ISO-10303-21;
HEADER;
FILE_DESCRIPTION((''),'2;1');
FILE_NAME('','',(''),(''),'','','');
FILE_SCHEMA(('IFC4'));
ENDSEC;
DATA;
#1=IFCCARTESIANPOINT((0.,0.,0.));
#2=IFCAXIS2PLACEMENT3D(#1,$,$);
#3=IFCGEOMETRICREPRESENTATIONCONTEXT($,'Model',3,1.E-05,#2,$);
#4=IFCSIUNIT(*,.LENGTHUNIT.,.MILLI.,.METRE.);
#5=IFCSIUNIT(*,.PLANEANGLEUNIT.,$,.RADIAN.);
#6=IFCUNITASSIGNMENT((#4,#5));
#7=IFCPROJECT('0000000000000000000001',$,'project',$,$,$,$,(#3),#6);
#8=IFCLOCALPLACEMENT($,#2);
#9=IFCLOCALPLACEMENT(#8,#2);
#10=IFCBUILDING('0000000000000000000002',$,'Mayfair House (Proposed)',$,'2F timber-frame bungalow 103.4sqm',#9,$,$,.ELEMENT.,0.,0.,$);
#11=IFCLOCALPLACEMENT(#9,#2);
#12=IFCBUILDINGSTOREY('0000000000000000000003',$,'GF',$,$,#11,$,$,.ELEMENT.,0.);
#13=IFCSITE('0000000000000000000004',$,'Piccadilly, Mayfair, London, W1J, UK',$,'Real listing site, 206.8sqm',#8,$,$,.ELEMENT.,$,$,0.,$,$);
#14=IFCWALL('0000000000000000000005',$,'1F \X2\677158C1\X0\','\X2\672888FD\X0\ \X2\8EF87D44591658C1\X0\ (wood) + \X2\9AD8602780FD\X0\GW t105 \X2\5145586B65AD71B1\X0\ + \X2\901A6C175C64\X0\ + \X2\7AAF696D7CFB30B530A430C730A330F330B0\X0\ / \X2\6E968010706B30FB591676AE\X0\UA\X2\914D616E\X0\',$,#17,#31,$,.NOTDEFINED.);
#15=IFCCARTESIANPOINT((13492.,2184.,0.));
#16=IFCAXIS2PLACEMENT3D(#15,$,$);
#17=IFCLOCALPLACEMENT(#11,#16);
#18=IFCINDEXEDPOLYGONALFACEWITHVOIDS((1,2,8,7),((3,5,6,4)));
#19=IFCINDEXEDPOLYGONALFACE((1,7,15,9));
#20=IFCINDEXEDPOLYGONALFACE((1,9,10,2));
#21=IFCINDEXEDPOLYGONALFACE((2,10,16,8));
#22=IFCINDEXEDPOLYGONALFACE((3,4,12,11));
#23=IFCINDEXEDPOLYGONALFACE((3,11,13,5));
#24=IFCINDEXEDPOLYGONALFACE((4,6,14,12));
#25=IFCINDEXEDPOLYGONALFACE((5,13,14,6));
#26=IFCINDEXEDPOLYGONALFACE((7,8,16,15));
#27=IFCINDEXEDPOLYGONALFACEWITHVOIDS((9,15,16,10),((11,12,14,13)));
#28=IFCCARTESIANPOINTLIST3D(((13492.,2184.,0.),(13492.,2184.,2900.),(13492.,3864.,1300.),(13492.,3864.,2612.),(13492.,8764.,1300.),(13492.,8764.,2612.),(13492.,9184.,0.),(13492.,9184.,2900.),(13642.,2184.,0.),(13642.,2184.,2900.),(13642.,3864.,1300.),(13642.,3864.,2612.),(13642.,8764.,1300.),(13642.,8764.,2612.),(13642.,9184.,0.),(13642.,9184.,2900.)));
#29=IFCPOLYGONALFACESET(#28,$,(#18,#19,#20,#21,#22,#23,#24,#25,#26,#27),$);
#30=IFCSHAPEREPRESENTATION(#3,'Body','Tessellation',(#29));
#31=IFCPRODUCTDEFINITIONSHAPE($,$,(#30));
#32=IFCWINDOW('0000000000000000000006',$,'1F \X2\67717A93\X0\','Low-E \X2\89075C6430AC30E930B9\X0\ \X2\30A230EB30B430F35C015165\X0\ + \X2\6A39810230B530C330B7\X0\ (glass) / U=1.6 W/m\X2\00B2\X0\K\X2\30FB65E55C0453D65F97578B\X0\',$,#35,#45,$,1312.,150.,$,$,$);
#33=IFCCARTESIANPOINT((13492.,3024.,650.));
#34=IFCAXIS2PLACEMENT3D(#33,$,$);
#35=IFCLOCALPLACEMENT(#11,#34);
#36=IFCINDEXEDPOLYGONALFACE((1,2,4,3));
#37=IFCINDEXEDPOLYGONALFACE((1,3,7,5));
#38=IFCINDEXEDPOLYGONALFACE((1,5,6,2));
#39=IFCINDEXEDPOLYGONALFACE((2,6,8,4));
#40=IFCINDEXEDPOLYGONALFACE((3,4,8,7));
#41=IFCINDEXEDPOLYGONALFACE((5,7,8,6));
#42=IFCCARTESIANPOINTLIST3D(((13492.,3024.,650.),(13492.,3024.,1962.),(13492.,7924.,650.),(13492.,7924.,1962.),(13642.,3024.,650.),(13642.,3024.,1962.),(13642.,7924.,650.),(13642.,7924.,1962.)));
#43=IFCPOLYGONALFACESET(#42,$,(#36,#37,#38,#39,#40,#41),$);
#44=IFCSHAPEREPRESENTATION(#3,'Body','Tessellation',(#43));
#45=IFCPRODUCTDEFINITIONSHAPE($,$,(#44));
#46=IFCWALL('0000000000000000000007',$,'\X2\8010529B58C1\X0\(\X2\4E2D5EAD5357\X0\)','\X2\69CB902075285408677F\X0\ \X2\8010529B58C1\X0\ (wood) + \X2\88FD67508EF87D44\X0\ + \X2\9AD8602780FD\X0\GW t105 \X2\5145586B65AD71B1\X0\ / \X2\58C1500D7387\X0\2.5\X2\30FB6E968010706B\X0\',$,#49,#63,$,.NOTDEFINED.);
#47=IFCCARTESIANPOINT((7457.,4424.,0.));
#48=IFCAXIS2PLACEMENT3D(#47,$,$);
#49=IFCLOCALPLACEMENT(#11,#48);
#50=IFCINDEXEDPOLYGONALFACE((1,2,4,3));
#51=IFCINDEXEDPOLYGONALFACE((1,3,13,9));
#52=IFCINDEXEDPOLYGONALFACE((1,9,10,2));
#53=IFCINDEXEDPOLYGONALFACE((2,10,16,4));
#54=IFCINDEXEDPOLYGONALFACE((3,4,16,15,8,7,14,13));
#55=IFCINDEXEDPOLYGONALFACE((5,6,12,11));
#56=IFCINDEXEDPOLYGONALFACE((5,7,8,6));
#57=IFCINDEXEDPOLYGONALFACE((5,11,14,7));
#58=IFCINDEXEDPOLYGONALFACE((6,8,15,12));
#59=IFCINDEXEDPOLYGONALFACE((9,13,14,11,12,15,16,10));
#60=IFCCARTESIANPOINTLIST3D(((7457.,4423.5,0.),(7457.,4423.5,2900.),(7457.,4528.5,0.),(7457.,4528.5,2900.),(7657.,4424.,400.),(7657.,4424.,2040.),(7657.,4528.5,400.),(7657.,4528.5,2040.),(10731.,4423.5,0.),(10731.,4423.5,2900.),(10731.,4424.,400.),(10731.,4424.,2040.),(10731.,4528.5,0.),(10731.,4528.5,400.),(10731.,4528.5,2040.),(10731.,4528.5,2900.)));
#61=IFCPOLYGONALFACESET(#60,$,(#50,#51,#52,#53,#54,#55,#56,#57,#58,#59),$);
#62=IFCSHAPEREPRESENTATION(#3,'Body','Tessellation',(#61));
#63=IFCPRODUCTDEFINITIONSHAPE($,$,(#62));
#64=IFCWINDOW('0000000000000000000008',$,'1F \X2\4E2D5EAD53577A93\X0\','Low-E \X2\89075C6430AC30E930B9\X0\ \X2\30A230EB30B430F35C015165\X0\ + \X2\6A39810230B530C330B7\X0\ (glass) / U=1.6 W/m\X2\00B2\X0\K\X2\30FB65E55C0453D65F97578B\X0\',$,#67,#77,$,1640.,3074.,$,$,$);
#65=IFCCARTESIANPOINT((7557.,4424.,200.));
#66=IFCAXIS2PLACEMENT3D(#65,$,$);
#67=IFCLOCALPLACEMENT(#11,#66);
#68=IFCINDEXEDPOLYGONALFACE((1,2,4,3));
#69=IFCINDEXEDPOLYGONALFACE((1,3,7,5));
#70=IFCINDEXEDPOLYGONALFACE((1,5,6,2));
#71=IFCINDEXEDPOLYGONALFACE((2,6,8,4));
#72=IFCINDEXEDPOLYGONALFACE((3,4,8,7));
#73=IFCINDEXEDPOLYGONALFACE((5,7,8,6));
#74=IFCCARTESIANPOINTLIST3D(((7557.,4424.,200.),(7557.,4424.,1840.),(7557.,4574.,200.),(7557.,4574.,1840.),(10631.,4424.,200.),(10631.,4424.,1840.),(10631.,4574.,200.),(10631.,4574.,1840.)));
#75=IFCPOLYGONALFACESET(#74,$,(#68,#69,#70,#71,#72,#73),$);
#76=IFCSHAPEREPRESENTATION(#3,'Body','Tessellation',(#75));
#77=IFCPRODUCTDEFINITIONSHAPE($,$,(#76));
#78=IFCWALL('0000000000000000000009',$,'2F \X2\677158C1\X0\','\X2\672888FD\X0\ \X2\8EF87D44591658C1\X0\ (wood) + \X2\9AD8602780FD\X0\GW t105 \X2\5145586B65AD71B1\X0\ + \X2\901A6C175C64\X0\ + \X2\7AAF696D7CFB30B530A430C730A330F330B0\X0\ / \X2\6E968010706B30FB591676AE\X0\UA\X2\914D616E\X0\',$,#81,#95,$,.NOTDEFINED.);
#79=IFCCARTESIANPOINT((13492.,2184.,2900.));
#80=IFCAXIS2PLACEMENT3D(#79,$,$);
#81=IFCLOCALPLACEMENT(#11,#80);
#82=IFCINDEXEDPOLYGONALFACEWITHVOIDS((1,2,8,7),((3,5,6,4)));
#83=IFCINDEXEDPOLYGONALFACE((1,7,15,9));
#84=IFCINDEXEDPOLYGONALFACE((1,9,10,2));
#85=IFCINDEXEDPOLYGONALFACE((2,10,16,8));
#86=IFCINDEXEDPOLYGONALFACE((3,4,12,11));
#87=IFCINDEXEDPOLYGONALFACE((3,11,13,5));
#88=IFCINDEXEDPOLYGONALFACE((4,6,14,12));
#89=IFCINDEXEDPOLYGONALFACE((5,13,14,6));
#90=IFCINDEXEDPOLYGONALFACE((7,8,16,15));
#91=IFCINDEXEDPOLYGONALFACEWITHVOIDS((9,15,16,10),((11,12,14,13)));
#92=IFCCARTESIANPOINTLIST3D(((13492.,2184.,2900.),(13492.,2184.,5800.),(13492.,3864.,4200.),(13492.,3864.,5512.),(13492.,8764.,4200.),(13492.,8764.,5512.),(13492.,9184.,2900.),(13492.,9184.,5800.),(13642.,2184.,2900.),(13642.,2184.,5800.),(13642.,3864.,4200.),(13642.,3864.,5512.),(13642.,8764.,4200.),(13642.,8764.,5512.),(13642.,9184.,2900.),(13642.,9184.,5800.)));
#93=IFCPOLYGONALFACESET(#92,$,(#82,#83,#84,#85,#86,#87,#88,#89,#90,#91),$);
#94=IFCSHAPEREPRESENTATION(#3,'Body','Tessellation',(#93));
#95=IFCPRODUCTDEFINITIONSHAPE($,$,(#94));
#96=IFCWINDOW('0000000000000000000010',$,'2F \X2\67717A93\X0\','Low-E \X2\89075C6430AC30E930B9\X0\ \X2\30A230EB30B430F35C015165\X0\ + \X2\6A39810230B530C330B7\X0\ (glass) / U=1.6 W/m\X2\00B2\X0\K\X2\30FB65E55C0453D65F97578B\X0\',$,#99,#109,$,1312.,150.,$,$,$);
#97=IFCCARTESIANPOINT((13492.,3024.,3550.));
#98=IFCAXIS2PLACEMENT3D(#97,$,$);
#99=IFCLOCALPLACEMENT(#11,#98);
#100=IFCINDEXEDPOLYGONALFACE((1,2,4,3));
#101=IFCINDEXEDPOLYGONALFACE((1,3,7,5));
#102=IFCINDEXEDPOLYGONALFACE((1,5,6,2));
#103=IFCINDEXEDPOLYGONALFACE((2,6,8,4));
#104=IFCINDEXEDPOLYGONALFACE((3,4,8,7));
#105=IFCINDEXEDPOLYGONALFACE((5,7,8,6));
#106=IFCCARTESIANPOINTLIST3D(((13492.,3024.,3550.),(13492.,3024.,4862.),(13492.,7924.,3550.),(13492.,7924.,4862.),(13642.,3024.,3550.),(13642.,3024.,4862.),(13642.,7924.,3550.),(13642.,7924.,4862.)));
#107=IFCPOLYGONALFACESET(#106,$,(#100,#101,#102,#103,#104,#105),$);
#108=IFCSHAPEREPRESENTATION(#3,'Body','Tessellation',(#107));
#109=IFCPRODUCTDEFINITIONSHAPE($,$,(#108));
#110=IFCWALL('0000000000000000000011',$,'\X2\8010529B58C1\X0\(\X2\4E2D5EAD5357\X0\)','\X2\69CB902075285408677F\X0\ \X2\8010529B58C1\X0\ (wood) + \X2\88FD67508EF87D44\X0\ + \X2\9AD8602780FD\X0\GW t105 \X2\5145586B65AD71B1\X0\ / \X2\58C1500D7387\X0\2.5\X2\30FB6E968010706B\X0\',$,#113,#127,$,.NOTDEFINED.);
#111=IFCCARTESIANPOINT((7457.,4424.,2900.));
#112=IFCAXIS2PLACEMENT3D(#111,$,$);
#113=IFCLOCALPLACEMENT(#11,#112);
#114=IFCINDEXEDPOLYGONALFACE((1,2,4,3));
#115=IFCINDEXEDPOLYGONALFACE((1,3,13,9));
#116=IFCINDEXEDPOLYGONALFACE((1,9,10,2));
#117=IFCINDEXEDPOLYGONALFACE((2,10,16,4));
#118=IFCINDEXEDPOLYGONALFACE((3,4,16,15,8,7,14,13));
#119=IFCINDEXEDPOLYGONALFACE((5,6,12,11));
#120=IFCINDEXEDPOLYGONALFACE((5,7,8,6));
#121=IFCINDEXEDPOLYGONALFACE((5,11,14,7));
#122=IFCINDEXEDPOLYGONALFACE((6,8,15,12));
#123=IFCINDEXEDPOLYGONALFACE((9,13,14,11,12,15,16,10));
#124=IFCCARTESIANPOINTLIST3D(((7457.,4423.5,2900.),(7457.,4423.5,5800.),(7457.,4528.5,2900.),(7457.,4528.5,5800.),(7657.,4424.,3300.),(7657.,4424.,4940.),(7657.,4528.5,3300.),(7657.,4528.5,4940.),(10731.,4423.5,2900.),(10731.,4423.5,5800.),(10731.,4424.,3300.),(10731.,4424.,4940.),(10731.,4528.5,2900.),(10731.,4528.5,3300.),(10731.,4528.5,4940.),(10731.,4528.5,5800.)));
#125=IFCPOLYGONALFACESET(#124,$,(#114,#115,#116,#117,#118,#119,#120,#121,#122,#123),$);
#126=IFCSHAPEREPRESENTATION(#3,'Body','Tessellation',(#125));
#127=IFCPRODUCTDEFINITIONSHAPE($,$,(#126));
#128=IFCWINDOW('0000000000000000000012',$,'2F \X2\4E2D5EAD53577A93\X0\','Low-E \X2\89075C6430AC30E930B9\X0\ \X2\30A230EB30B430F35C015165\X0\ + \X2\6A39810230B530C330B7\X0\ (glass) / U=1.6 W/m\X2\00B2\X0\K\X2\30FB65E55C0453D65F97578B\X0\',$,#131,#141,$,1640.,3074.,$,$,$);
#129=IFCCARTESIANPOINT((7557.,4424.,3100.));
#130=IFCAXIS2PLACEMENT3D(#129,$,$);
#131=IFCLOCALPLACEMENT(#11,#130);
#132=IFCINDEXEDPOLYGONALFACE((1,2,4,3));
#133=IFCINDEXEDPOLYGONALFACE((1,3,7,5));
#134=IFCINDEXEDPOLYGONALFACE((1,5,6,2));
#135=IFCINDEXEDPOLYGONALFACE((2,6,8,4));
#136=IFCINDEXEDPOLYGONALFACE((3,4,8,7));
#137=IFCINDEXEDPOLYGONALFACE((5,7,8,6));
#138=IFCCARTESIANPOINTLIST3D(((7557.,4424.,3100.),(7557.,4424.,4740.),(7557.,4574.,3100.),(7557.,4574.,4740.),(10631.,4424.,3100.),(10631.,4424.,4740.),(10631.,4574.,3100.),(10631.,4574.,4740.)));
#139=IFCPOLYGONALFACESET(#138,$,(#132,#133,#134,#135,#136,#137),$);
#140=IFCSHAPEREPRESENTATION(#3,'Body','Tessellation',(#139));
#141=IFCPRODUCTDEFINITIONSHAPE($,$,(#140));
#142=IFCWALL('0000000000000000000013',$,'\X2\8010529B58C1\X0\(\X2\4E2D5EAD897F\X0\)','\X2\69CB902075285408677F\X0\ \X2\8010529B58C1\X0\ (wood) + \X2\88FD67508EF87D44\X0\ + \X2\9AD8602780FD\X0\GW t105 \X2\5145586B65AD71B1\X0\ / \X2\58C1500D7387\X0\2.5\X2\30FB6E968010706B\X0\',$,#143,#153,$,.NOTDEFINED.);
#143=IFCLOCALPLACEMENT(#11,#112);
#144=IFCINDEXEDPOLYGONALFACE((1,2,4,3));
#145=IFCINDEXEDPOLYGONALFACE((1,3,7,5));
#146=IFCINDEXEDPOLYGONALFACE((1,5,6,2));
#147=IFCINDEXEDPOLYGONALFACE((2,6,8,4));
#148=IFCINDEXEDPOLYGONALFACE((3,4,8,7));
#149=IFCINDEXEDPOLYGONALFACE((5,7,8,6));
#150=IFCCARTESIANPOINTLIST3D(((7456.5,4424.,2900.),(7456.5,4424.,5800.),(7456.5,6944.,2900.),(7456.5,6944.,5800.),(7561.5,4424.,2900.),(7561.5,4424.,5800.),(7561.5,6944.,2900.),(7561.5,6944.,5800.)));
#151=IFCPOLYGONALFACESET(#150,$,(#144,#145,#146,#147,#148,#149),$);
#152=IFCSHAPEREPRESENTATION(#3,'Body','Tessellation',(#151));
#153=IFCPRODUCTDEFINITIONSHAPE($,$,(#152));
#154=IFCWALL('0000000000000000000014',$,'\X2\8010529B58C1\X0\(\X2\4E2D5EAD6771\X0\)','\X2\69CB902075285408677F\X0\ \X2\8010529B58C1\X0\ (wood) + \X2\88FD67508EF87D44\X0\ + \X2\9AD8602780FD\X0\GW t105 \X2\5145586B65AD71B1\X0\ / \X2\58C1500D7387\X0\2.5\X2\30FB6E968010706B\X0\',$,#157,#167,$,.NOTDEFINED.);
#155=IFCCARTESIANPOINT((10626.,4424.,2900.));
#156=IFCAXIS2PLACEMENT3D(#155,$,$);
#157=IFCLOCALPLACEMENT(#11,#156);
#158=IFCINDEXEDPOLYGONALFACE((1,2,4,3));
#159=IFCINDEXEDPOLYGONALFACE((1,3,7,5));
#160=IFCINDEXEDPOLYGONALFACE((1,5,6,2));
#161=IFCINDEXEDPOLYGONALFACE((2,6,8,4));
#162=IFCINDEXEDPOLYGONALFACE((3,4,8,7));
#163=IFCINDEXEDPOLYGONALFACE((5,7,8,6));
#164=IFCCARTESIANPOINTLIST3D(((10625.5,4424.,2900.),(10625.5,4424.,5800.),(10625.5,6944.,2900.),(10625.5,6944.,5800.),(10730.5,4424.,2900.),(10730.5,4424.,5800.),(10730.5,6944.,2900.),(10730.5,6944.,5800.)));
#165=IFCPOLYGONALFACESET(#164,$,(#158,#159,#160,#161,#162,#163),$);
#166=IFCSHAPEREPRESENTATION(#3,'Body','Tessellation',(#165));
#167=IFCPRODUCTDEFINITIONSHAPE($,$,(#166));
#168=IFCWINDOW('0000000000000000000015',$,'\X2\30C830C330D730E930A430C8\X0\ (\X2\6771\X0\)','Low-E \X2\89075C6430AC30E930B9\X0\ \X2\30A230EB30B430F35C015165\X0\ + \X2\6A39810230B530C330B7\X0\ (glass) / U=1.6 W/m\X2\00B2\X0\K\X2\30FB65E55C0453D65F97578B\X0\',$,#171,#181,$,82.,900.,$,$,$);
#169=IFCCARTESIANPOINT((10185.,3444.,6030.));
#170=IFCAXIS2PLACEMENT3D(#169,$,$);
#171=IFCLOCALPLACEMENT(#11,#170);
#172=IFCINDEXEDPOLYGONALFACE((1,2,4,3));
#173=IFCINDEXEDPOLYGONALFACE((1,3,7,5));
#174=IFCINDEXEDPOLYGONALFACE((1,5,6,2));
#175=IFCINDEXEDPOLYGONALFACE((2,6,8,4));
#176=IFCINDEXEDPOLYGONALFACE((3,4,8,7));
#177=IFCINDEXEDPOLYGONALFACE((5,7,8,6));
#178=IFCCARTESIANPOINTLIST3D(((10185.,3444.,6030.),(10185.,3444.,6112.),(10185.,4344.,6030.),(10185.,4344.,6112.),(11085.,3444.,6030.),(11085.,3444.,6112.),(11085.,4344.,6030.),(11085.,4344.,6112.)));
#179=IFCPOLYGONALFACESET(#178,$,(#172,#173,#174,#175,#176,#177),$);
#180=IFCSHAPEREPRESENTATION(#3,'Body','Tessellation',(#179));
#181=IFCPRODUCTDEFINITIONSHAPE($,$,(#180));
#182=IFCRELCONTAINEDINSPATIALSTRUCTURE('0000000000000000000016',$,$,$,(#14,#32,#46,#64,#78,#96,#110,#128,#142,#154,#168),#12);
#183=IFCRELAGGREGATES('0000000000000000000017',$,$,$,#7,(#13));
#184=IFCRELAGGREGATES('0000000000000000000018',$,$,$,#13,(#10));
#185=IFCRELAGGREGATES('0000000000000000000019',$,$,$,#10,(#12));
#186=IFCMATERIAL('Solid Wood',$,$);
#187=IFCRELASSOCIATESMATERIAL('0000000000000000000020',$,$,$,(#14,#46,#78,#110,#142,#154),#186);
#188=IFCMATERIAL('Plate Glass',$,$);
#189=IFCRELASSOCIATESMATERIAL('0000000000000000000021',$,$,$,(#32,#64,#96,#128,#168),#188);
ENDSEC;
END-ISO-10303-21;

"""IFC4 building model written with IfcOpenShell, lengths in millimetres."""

from ifc_helpers import new_model, si_unit, frame, frame_2d, origin, place, context, project, spatial, rectangle, extrude, material, element, fill, save


model = new_model("IFC4")

# Units and contexts
model_context = context("Model", 3, precision=1e-05, world=origin())
ifc_project = project(units=[si_unit("LENGTHUNIT", "METRE", prefix="MILLI"), si_unit("PLANEANGLEUNIT", "RADIAN")], contexts=[model_context])

# Site, building, storey
site_placement = place(None, origin())
site = spatial("IfcSite", under=ifc_project, at=site_placement, Name="Piccadilly, Mayfair, London, W1J, UK", ObjectType="Real listing site, 206.8sqm", CompositionType="ELEMENT", RefElevation=0.0)
building_placement = place(site_placement, origin())
building = spatial("IfcBuilding", under=site, at=building_placement, Name="Mayfair House (Proposed)", ObjectType="2F timber-frame bungalow 103.4sqm", CompositionType="ELEMENT", ElevationOfRefHeight=0.0, ElevationOfTerrain=0.0)
storey_placement = place(building_placement, origin())
storey = spatial("IfcBuildingStorey", under=building, at=storey_placement, Name="GF", CompositionType="ELEMENT", Elevation=0.0)

# Shared definitions
ifc_material_1 = material(Name="Solid Wood")

# Walls, openings, windows
wall_1_placement = place(storey_placement, frame((13492.0, 2184.0, 0.0)))
wall_1 = element("IfcWall", 1, at=wall_1_placement, inside=storey, material=ifc_material_1, Name="1F 東壁", Description="木製 軸組外壁 (wood) + 高性能GW t105 充填断熱 + 通気層 + 窯業系サイディング / 準耐火・外皮UA配慮", PredefinedType="NOTDEFINED", context=model_context, shape_type="SweptSolid", body=[
    extrude(rectangle(XDim=150.0, YDim=7000.0, at=frame_2d((75.0, 3500.0))), frame((13492.0, 2184.0, 0.0)), (0.0, 0.0, 1.0), 2900.0),
])
opening_1_placement = place(storey_placement, frame((13492.0, 3024.0, 650.0)))
opening_1 = element("IfcOpeningElement", 2, at=opening_1_placement, cuts=wall_1, PredefinedType="NOTDEFINED", context=model_context, shape_type="SweptSolid", body=[
    extrude(rectangle(XDim=150.0, YDim=4900.0, at=frame_2d((75.0, 2450.0))), frame((13492.0, 3024.0, 650.0)), (0.0, 0.0, 1.0), 1312.0),
])
ifc_material_2 = material(Name="Plate Glass")
window_1_placement = place(storey_placement, frame((13492.0, 3024.0, 650.0)))
window_1 = element("IfcWindow", 3, at=window_1_placement, inside=storey, material=ifc_material_2, Name="1F 東窓", Description="Low-E 複層ガラス アルゴン封入 + 樹脂サッシ (glass) / U=1.6 W/m²K・日射取得型", OverallHeight=1312.0, OverallWidth=150.0, context=model_context, shape_type="SweptSolid", body=[
    extrude(rectangle(XDim=150.0, YDim=4900.0, at=frame_2d((75.0, 2450.0))), frame((13492.0, 3024.0, 650.0)), (0.0, 0.0, 1.0), 1312.0),
])
fill(opening_1, window_1)
wall_2_placement = place(storey_placement, frame((7457.0, 4424.0, 0.0)))
wall_2 = element("IfcWall", 4, at=wall_2_placement, inside=storey, material=ifc_material_1, Name="耐力壁(中庭南)", Description="構造用合板 耐力壁 (wood) + 製材軸組 + 高性能GW t105 充填断熱 / 壁倍率2.5・準耐火", PredefinedType="NOTDEFINED", context=model_context, shape_type="SweptSolid", body=[
    extrude(rectangle(XDim=3274.0, YDim=105.0, at=frame_2d((1637.0, 52.0))), frame((7457.0, 4424.0, 0.0)), (0.0, 0.0, 1.0), 2900.0),
])
opening_2_placement = place(storey_placement, frame((7557.0, 4424.0, 200.0)))
opening_2 = element("IfcOpeningElement", 5, at=opening_2_placement, cuts=wall_2, PredefinedType="NOTDEFINED", context=model_context, shape_type="SweptSolid", body=[
    extrude(rectangle(XDim=3074.0, YDim=150.0, at=frame_2d((1537.0, 75.0))), frame((7557.0, 4424.0, 200.0)), (0.0, 0.0, 1.0), 1640.0),
])
window_2_placement = place(storey_placement, frame((7557.0, 4424.0, 200.0)))
window_2 = element("IfcWindow", 6, at=window_2_placement, inside=storey, material=ifc_material_2, Name="1F 中庭南窓", Description="Low-E 複層ガラス アルゴン封入 + 樹脂サッシ (glass) / U=1.6 W/m²K・日射取得型", OverallHeight=1640.0, OverallWidth=3074.0, context=model_context, shape_type="SweptSolid", body=[
    extrude(rectangle(XDim=3074.0, YDim=150.0, at=frame_2d((1537.0, 75.0))), frame((7557.0, 4424.0, 200.0)), (0.0, 0.0, 1.0), 1640.0),
])
fill(opening_2, window_2)

# Walls, openings, windows
wall_3_placement = place(storey_placement, frame((13492.0, 2184.0, 2900.0)))
wall_3 = element("IfcWall", 7, at=wall_3_placement, inside=storey, material=ifc_material_1, Name="2F 東壁", Description="木製 軸組外壁 (wood) + 高性能GW t105 充填断熱 + 通気層 + 窯業系サイディング / 準耐火・外皮UA配慮", PredefinedType="NOTDEFINED", context=model_context, shape_type="SweptSolid", body=[
    extrude(rectangle(XDim=150.0, YDim=7000.0, at=frame_2d((75.0, 3500.0))), frame((13492.0, 2184.0, 2900.0)), (0.0, 0.0, 1.0), 2900.0),
])
opening_3_placement = place(storey_placement, frame((13492.0, 3024.0, 3550.0)))
opening_3 = element("IfcOpeningElement", 8, at=opening_3_placement, cuts=wall_3, PredefinedType="NOTDEFINED", context=model_context, shape_type="SweptSolid", body=[
    extrude(rectangle(XDim=150.0, YDim=4900.0, at=frame_2d((75.0, 2450.0))), frame((13492.0, 3024.0, 3550.0)), (0.0, 0.0, 1.0), 1312.0),
])
window_3_placement = place(storey_placement, frame((13492.0, 3024.0, 3550.0)))
window_3 = element("IfcWindow", 9, at=window_3_placement, inside=storey, material=ifc_material_2, Name="2F 東窓", Description="Low-E 複層ガラス アルゴン封入 + 樹脂サッシ (glass) / U=1.6 W/m²K・日射取得型", OverallHeight=1312.0, OverallWidth=150.0, context=model_context, shape_type="SweptSolid", body=[
    extrude(rectangle(XDim=150.0, YDim=4900.0, at=frame_2d((75.0, 2450.0))), frame((13492.0, 3024.0, 3550.0)), (0.0, 0.0, 1.0), 1312.0),
])
fill(opening_3, window_3)
wall_4_placement = place(storey_placement, frame((7457.0, 4424.0, 2900.0)))
wall_4 = element("IfcWall", 10, at=wall_4_placement, inside=storey, material=ifc_material_1, Name="耐力壁(中庭南)", Description="構造用合板 耐力壁 (wood) + 製材軸組 + 高性能GW t105 充填断熱 / 壁倍率2.5・準耐火", PredefinedType="NOTDEFINED", context=model_context, shape_type="SweptSolid", body=[
    extrude(rectangle(XDim=3274.0, YDim=105.0, at=frame_2d((1637.0, 52.0))), frame((7457.0, 4424.0, 2900.0)), (0.0, 0.0, 1.0), 2900.0),
])
opening_4_placement = place(storey_placement, frame((7557.0, 4424.0, 3100.0)))
opening_4 = element("IfcOpeningElement", 11, at=opening_4_placement, cuts=wall_4, PredefinedType="NOTDEFINED", context=model_context, shape_type="SweptSolid", body=[
    extrude(rectangle(XDim=3074.0, YDim=150.0, at=frame_2d((1537.0, 75.0))), frame((7557.0, 4424.0, 3100.0)), (0.0, 0.0, 1.0), 1640.0),
])
window_4_placement = place(storey_placement, frame((7557.0, 4424.0, 3100.0)))
window_4 = element("IfcWindow", 12, at=window_4_placement, inside=storey, material=ifc_material_2, Name="2F 中庭南窓", Description="Low-E 複層ガラス アルゴン封入 + 樹脂サッシ (glass) / U=1.6 W/m²K・日射取得型", OverallHeight=1640.0, OverallWidth=3074.0, context=model_context, shape_type="SweptSolid", body=[
    extrude(rectangle(XDim=3074.0, YDim=150.0, at=frame_2d((1537.0, 75.0))), frame((7557.0, 4424.0, 3100.0)), (0.0, 0.0, 1.0), 1640.0),
])
fill(opening_4, window_4)

# Walls
wall_5_placement = place(storey_placement, frame((7457.0, 4424.0, 2900.0)))
element("IfcWall", 13, at=wall_5_placement, inside=storey, material=ifc_material_1, Name="耐力壁(中庭西)", Description="構造用合板 耐力壁 (wood) + 製材軸組 + 高性能GW t105 充填断熱 / 壁倍率2.5・準耐火", PredefinedType="NOTDEFINED", context=model_context, shape_type="SweptSolid", body=[
    extrude(rectangle(XDim=105.0, YDim=2520.0, at=frame_2d((52.0, 1260.0))), frame((7457.0, 4424.0, 2900.0)), (0.0, 0.0, 1.0), 2900.0),
])
wall_6_placement = place(storey_placement, frame((10626.0, 4424.0, 2900.0)))
element("IfcWall", 14, at=wall_6_placement, inside=storey, material=ifc_material_1, Name="耐力壁(中庭東)", Description="構造用合板 耐力壁 (wood) + 製材軸組 + 高性能GW t105 充填断熱 / 壁倍率2.5・準耐火", PredefinedType="NOTDEFINED", context=model_context, shape_type="SweptSolid", body=[
    extrude(rectangle(XDim=105.0, YDim=2520.0, at=frame_2d((52.0, 1260.0))), frame((10626.0, 4424.0, 2900.0)), (0.0, 0.0, 1.0), 2900.0),
])

# Window
window_5_placement = place(storey_placement, frame((10185.0, 3444.0, 6030.0)))
element("IfcWindow", 15, at=window_5_placement, inside=storey, material=ifc_material_2, Name="トップライト (東)", Description="Low-E 複層ガラス アルゴン封入 + 樹脂サッシ (glass) / U=1.6 W/m²K・日射取得型", OverallHeight=82.0, OverallWidth=900.0, context=model_context, shape_type="SweptSolid", body=[
    extrude(rectangle(XDim=900.0, YDim=900.0, at=frame_2d((450.0, 450.0))), frame((10185.0, 3444.0, 6030.0)), (0.0, 0.0, 1.0), 82.0),
])

save(model, "model.ifc")
